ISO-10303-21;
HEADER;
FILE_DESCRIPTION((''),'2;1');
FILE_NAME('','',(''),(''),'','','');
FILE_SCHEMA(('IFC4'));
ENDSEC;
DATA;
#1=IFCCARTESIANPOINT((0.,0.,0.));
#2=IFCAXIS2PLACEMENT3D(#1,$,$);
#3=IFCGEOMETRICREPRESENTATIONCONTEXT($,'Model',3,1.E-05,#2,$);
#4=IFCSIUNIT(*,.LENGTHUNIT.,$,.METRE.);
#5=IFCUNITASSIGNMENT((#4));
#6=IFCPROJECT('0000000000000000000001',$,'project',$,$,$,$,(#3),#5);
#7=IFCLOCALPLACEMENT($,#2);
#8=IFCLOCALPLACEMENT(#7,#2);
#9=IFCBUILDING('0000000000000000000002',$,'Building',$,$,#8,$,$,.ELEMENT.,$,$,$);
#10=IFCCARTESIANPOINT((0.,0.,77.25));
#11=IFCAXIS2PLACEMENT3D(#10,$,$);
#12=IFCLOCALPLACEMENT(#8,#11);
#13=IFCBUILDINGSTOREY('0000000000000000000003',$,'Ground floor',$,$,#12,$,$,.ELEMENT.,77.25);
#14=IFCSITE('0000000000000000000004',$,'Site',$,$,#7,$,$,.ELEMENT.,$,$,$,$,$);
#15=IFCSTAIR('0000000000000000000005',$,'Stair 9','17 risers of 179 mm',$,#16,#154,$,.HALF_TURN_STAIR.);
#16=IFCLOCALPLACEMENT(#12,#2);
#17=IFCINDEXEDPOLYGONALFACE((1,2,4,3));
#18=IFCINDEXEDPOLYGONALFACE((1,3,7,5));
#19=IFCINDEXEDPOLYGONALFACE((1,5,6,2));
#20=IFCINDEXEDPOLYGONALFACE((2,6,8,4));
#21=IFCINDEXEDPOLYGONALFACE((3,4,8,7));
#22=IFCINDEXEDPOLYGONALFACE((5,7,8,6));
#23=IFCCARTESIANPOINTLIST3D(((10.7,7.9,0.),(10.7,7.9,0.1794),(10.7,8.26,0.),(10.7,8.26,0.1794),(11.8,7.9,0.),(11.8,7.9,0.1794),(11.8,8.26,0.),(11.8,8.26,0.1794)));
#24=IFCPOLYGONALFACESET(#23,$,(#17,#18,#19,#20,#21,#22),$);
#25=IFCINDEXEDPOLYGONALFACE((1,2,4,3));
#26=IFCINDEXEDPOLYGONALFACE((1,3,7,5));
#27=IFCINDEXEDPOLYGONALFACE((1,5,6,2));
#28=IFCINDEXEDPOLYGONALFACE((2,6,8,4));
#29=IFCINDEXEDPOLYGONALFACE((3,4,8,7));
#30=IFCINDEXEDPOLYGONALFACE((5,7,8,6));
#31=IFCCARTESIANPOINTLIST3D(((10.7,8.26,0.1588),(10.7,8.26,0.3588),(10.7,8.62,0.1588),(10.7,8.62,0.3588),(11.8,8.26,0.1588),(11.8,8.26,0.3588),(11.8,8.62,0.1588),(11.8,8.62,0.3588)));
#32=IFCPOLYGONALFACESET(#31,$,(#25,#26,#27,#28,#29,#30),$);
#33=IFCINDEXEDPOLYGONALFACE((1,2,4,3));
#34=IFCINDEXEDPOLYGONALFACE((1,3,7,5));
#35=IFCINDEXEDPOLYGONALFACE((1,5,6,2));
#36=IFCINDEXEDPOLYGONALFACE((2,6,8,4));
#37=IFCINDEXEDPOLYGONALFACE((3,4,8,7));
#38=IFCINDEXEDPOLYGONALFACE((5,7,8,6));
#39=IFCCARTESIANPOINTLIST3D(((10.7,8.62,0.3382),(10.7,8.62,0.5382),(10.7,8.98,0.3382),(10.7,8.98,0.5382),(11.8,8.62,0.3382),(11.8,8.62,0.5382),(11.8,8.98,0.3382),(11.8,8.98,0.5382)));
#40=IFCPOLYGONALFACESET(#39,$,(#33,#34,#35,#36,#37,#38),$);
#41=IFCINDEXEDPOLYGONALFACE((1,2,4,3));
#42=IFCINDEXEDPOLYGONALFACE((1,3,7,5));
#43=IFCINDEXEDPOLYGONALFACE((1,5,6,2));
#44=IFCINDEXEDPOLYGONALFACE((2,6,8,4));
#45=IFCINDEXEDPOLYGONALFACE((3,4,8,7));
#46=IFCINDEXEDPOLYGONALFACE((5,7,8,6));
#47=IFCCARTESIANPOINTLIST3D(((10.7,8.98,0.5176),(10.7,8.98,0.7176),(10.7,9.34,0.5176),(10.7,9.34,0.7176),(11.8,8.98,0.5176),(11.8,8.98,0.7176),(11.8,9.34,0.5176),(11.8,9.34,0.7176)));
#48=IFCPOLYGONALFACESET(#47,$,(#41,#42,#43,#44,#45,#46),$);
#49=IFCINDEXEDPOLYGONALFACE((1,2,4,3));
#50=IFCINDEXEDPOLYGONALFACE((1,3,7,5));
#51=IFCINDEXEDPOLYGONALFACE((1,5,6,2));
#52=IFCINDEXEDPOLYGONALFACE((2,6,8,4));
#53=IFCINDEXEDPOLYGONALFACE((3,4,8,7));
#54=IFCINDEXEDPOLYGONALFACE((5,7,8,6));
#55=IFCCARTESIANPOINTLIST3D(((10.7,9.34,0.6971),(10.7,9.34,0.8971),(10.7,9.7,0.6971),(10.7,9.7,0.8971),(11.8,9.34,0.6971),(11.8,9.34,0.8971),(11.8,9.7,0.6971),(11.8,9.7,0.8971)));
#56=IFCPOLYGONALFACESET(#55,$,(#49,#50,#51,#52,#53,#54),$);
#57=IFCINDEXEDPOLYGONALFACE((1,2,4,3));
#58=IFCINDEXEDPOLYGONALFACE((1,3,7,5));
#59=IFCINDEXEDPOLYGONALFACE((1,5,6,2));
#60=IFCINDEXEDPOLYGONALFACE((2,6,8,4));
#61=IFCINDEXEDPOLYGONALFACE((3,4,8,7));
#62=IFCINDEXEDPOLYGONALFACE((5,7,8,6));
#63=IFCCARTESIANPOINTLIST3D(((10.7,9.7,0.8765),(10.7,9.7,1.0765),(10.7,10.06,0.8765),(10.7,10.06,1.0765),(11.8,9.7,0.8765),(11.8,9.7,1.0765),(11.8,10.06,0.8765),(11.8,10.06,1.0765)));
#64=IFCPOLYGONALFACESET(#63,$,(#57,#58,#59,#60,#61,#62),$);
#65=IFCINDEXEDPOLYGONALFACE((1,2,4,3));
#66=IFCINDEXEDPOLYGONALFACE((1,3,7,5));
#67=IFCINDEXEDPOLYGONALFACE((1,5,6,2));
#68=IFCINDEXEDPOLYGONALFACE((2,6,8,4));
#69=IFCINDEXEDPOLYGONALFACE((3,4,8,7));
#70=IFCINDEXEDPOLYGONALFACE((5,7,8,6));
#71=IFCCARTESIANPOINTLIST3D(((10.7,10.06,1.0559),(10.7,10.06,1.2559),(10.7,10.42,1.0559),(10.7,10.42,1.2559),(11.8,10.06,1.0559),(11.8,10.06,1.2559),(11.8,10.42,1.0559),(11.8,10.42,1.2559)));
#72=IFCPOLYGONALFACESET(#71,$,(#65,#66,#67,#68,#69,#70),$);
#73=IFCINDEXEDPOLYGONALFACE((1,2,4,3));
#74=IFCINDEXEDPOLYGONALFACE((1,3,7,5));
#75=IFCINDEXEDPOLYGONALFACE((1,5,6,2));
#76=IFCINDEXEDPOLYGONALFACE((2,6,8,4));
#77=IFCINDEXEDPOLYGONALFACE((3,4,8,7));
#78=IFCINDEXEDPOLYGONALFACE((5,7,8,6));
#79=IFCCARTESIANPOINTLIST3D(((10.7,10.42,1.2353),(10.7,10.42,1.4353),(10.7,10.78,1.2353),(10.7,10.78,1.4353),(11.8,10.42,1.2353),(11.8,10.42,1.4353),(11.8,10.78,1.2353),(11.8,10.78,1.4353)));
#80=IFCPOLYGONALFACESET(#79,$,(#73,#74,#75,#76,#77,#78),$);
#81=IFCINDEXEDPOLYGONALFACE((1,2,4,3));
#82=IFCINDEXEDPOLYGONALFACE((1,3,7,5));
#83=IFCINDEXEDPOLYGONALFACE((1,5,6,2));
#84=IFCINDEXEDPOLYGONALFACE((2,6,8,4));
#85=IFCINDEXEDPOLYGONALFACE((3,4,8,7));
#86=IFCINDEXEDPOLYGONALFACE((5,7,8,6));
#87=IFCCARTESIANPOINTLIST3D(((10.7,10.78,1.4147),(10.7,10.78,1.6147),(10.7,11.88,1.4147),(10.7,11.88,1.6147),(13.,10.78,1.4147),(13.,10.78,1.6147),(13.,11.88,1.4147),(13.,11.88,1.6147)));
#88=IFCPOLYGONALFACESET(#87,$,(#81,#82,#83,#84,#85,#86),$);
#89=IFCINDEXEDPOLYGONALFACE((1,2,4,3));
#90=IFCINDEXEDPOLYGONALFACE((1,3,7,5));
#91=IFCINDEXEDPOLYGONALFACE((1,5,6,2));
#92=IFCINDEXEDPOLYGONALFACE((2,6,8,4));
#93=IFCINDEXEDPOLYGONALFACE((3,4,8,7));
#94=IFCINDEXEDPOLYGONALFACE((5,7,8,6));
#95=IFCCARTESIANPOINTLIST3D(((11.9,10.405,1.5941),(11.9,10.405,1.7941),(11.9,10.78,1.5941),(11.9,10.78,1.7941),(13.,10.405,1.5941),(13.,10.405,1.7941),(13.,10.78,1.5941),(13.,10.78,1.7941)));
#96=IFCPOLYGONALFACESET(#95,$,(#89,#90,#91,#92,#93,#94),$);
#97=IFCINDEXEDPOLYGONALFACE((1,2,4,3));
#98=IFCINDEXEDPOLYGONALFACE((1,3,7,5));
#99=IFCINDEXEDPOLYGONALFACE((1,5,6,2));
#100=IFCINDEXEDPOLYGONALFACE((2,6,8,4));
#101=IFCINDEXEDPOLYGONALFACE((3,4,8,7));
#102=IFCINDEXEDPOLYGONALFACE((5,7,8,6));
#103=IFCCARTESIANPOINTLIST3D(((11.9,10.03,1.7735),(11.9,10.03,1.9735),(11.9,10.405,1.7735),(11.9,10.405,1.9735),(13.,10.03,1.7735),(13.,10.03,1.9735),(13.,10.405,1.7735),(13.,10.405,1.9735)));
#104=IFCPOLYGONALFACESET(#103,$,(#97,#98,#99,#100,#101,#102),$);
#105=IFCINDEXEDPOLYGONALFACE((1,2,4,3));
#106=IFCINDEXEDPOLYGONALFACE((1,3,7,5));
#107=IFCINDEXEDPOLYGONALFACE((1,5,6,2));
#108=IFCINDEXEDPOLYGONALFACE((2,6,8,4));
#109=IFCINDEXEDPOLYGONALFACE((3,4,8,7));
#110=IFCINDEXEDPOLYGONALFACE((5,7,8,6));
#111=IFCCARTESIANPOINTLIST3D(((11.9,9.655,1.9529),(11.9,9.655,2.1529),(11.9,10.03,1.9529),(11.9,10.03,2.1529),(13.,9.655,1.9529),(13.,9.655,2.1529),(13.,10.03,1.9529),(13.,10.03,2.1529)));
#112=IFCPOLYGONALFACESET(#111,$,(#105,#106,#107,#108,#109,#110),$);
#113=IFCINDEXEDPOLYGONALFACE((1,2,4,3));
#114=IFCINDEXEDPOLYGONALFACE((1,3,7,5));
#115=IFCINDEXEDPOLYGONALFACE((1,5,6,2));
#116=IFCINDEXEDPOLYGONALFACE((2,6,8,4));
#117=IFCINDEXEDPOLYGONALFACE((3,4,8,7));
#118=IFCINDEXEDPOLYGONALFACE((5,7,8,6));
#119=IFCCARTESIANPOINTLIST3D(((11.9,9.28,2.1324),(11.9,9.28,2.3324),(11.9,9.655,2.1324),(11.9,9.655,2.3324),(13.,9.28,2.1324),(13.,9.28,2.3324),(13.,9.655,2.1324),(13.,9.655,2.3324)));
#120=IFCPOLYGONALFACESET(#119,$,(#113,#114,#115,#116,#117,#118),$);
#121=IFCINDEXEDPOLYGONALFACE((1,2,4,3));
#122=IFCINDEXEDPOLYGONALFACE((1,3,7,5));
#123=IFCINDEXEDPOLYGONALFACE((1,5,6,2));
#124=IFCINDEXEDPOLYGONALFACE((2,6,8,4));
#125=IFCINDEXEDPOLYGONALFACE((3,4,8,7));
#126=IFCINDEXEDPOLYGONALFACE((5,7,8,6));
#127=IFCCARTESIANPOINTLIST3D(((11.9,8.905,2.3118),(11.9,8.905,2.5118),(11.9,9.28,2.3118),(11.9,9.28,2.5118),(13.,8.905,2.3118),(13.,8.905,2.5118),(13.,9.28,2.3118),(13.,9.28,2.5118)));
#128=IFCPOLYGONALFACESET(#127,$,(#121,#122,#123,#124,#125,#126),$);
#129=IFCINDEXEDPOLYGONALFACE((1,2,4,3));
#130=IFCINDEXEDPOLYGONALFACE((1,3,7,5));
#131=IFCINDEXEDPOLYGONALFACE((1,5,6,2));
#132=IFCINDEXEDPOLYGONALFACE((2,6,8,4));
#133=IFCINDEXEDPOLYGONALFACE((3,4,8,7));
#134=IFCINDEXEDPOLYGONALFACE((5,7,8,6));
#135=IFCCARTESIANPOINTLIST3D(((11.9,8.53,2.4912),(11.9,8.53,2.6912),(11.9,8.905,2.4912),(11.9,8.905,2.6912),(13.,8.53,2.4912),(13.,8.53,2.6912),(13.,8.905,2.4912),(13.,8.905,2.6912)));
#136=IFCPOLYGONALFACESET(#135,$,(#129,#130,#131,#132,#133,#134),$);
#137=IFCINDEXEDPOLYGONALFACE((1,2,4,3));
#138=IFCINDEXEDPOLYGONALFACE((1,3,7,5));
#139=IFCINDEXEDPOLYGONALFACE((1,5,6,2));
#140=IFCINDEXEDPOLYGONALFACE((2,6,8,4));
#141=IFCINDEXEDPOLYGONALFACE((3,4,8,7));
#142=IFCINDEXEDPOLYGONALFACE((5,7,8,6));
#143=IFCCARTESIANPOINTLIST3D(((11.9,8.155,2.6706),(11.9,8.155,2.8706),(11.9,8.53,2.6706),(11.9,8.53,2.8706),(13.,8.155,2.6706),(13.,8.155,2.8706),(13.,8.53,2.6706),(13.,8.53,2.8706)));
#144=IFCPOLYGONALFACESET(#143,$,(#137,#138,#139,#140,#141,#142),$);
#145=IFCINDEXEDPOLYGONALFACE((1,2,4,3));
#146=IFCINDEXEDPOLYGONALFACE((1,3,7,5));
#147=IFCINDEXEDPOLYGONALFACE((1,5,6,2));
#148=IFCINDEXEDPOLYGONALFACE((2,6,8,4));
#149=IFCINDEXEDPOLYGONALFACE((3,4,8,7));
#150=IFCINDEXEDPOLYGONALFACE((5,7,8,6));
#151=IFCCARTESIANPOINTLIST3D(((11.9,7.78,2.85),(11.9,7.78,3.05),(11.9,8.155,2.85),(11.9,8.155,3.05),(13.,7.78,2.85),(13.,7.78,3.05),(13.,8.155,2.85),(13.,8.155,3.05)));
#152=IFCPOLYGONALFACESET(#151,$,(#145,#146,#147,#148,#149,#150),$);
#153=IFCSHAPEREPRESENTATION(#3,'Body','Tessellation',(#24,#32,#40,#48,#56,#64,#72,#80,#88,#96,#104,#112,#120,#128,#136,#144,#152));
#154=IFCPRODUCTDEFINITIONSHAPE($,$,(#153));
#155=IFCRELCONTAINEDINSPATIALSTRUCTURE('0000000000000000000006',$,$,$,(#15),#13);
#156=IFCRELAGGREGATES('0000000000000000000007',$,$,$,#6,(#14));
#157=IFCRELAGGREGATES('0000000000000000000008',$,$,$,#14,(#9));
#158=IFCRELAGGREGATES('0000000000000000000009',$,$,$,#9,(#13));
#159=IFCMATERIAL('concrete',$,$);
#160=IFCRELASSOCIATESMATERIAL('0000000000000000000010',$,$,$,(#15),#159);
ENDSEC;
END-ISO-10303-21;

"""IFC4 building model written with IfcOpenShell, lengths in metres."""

from ifc_helpers import new_model, si_unit, frame, origin, place, context, project, spatial, polyline, outline, extrude, material, element, save


model = new_model("IFC4")

# Units and contexts
model_context = context("Model", 3, precision=1e-05, world=origin())
ifc_project = project(units=[si_unit("LENGTHUNIT", "METRE")], contexts=[model_context])

# Site, building, storey
site_placement = place(None, origin())
site = spatial("IfcSite", under=ifc_project, at=site_placement, Name="Site", CompositionType="ELEMENT")
building_placement = place(site_placement, origin())
building = spatial("IfcBuilding", under=site, at=building_placement, Name="Building", CompositionType="ELEMENT")
storey_placement = place(building_placement, frame((0.0, 0.0, 77.25)))
storey = spatial("IfcBuildingStorey", under=building, at=storey_placement, Name="Ground floor", CompositionType="ELEMENT", Elevation=77.25)

# Shared definitions
ifc_material = material(Name="concrete")

# Stair
stair_1_placement = place(storey_placement, frame((11.25, 7.9, 0.0), z_axis=(0.0, 0.0, 1.0), x_axis=(0.0, 1.0, 0.0)))
element("IfcStair", 1, at=stair_1_placement, inside=storey, material=ifc_material, Name="Stair 9", Description="17 risers of 179 mm", PredefinedType="HALF_TURN_STAIR", context=model_context, shape_type="SweptSolid", body=[
    extrude(outline(polyline([(0.0, -0.55), (0.36, -0.55), (0.36, 0.55), (0.0, 0.55), (0.0, -0.55)])), origin(), (0.0, 0.0, 1.0), 0.1794),
    extrude(outline(polyline([(0.36, -0.55), (0.72, -0.55), (0.72, 0.55), (0.36, 0.55), (0.36, -0.55)])), frame((0.0, 0.0, 0.1588)), (0.0, 0.0, 1.0), 0.2),
    extrude(outline(polyline([(0.72, -0.55), (1.08, -0.55), (1.08, 0.55), (0.72, 0.55), (0.72, -0.55)])), frame((0.0, 0.0, 0.3382)), (0.0, 0.0, 1.0), 0.2),
    extrude(outline(polyline([(1.08, -0.55), (1.44, -0.55), (1.44, 0.55), (1.08, 0.55), (1.08, -0.55)])), frame((0.0, 0.0, 0.5176)), (0.0, 0.0, 1.0), 0.2),
    extrude(outline(polyline([(1.44, -0.55), (1.8, -0.55), (1.8, 0.55), (1.44, 0.55), (1.44, -0.55)])), frame((0.0, 0.0, 0.6971)), (0.0, 0.0, 1.0), 0.2),
    extrude(outline(polyline([(1.8, -0.55), (2.16, -0.55), (2.16, 0.55), (1.8, 0.55), (1.8, -0.55)])), frame((0.0, 0.0, 0.8765)), (0.0, 0.0, 1.0), 0.2),
    extrude(outline(polyline([(2.16, -0.55), (2.52, -0.55), (2.52, 0.55), (2.16, 0.55), (2.16, -0.55)])), frame((0.0, 0.0, 1.0559)), (0.0, 0.0, 1.0), 0.2),
    extrude(outline(polyline([(2.52, -0.55), (2.88, -0.55), (2.88, 0.55), (2.52, 0.55), (2.52, -0.55)])), frame((0.0, 0.0, 1.2353)), (0.0, 0.0, 1.0), 0.2),
    extrude(outline(polyline([(2.88, -1.75), (3.98, -1.75), (3.98, 0.55), (2.88, 0.55), (2.88, -1.75)])), frame((0.0, 0.0, 1.4147)), (0.0, 0.0, 1.0), 0.2),
    extrude(outline(polyline([(2.505, -1.75), (2.88, -1.75), (2.88, -0.65), (2.505, -0.65), (2.505, -1.75)])), frame((0.0, 0.0, 1.5941)), (0.0, 0.0, 1.0), 0.2),
    extrude(outline(polyline([(2.13, -1.75), (2.505, -1.75), (2.505, -0.65), (2.13, -0.65), (2.13, -1.75)])), frame((0.0, 0.0, 1.7735)), (0.0, 0.0, 1.0), 0.2),
    extrude(outline(polyline([(1.755, -1.75), (2.13, -1.75), (2.13, -0.65), (1.755, -0.65), (1.755, -1.75)])), frame((0.0, 0.0, 1.9529)), (0.0, 0.0, 1.0), 0.2),
    extrude(outline(polyline([(1.38, -1.75), (1.755, -1.75), (1.755, -0.65), (1.38, -0.65), (1.38, -1.75)])), frame((0.0, 0.0, 2.1324)), (0.0, 0.0, 1.0), 0.2),
    extrude(outline(polyline([(1.005, -1.75), (1.38, -1.75), (1.38, -0.65), (1.005, -0.65), (1.005, -1.75)])), frame((0.0, 0.0, 2.3118)), (0.0, 0.0, 1.0), 0.2),
    extrude(outline(polyline([(0.63, -1.75), (1.005, -1.75), (1.005, -0.65), (0.63, -0.65), (0.63, -1.75)])), frame((0.0, 0.0, 2.4912)), (0.0, 0.0, 1.0), 0.2),
    extrude(outline(polyline([(0.255, -1.75), (0.63, -1.75), (0.63, -0.65), (0.255, -0.65), (0.255, -1.75)])), frame((0.0, 0.0, 2.6706)), (0.0, 0.0, 1.0), 0.2),
    extrude(outline(polyline([(-0.12, -1.75), (0.255, -1.75), (0.255, -0.65), (-0.12, -0.65), (-0.12, -1.75)])), frame((0.0, 0.0, 2.85)), (0.0, 0.0, 1.0), 0.2),
])

save(model, "model.ifc")
